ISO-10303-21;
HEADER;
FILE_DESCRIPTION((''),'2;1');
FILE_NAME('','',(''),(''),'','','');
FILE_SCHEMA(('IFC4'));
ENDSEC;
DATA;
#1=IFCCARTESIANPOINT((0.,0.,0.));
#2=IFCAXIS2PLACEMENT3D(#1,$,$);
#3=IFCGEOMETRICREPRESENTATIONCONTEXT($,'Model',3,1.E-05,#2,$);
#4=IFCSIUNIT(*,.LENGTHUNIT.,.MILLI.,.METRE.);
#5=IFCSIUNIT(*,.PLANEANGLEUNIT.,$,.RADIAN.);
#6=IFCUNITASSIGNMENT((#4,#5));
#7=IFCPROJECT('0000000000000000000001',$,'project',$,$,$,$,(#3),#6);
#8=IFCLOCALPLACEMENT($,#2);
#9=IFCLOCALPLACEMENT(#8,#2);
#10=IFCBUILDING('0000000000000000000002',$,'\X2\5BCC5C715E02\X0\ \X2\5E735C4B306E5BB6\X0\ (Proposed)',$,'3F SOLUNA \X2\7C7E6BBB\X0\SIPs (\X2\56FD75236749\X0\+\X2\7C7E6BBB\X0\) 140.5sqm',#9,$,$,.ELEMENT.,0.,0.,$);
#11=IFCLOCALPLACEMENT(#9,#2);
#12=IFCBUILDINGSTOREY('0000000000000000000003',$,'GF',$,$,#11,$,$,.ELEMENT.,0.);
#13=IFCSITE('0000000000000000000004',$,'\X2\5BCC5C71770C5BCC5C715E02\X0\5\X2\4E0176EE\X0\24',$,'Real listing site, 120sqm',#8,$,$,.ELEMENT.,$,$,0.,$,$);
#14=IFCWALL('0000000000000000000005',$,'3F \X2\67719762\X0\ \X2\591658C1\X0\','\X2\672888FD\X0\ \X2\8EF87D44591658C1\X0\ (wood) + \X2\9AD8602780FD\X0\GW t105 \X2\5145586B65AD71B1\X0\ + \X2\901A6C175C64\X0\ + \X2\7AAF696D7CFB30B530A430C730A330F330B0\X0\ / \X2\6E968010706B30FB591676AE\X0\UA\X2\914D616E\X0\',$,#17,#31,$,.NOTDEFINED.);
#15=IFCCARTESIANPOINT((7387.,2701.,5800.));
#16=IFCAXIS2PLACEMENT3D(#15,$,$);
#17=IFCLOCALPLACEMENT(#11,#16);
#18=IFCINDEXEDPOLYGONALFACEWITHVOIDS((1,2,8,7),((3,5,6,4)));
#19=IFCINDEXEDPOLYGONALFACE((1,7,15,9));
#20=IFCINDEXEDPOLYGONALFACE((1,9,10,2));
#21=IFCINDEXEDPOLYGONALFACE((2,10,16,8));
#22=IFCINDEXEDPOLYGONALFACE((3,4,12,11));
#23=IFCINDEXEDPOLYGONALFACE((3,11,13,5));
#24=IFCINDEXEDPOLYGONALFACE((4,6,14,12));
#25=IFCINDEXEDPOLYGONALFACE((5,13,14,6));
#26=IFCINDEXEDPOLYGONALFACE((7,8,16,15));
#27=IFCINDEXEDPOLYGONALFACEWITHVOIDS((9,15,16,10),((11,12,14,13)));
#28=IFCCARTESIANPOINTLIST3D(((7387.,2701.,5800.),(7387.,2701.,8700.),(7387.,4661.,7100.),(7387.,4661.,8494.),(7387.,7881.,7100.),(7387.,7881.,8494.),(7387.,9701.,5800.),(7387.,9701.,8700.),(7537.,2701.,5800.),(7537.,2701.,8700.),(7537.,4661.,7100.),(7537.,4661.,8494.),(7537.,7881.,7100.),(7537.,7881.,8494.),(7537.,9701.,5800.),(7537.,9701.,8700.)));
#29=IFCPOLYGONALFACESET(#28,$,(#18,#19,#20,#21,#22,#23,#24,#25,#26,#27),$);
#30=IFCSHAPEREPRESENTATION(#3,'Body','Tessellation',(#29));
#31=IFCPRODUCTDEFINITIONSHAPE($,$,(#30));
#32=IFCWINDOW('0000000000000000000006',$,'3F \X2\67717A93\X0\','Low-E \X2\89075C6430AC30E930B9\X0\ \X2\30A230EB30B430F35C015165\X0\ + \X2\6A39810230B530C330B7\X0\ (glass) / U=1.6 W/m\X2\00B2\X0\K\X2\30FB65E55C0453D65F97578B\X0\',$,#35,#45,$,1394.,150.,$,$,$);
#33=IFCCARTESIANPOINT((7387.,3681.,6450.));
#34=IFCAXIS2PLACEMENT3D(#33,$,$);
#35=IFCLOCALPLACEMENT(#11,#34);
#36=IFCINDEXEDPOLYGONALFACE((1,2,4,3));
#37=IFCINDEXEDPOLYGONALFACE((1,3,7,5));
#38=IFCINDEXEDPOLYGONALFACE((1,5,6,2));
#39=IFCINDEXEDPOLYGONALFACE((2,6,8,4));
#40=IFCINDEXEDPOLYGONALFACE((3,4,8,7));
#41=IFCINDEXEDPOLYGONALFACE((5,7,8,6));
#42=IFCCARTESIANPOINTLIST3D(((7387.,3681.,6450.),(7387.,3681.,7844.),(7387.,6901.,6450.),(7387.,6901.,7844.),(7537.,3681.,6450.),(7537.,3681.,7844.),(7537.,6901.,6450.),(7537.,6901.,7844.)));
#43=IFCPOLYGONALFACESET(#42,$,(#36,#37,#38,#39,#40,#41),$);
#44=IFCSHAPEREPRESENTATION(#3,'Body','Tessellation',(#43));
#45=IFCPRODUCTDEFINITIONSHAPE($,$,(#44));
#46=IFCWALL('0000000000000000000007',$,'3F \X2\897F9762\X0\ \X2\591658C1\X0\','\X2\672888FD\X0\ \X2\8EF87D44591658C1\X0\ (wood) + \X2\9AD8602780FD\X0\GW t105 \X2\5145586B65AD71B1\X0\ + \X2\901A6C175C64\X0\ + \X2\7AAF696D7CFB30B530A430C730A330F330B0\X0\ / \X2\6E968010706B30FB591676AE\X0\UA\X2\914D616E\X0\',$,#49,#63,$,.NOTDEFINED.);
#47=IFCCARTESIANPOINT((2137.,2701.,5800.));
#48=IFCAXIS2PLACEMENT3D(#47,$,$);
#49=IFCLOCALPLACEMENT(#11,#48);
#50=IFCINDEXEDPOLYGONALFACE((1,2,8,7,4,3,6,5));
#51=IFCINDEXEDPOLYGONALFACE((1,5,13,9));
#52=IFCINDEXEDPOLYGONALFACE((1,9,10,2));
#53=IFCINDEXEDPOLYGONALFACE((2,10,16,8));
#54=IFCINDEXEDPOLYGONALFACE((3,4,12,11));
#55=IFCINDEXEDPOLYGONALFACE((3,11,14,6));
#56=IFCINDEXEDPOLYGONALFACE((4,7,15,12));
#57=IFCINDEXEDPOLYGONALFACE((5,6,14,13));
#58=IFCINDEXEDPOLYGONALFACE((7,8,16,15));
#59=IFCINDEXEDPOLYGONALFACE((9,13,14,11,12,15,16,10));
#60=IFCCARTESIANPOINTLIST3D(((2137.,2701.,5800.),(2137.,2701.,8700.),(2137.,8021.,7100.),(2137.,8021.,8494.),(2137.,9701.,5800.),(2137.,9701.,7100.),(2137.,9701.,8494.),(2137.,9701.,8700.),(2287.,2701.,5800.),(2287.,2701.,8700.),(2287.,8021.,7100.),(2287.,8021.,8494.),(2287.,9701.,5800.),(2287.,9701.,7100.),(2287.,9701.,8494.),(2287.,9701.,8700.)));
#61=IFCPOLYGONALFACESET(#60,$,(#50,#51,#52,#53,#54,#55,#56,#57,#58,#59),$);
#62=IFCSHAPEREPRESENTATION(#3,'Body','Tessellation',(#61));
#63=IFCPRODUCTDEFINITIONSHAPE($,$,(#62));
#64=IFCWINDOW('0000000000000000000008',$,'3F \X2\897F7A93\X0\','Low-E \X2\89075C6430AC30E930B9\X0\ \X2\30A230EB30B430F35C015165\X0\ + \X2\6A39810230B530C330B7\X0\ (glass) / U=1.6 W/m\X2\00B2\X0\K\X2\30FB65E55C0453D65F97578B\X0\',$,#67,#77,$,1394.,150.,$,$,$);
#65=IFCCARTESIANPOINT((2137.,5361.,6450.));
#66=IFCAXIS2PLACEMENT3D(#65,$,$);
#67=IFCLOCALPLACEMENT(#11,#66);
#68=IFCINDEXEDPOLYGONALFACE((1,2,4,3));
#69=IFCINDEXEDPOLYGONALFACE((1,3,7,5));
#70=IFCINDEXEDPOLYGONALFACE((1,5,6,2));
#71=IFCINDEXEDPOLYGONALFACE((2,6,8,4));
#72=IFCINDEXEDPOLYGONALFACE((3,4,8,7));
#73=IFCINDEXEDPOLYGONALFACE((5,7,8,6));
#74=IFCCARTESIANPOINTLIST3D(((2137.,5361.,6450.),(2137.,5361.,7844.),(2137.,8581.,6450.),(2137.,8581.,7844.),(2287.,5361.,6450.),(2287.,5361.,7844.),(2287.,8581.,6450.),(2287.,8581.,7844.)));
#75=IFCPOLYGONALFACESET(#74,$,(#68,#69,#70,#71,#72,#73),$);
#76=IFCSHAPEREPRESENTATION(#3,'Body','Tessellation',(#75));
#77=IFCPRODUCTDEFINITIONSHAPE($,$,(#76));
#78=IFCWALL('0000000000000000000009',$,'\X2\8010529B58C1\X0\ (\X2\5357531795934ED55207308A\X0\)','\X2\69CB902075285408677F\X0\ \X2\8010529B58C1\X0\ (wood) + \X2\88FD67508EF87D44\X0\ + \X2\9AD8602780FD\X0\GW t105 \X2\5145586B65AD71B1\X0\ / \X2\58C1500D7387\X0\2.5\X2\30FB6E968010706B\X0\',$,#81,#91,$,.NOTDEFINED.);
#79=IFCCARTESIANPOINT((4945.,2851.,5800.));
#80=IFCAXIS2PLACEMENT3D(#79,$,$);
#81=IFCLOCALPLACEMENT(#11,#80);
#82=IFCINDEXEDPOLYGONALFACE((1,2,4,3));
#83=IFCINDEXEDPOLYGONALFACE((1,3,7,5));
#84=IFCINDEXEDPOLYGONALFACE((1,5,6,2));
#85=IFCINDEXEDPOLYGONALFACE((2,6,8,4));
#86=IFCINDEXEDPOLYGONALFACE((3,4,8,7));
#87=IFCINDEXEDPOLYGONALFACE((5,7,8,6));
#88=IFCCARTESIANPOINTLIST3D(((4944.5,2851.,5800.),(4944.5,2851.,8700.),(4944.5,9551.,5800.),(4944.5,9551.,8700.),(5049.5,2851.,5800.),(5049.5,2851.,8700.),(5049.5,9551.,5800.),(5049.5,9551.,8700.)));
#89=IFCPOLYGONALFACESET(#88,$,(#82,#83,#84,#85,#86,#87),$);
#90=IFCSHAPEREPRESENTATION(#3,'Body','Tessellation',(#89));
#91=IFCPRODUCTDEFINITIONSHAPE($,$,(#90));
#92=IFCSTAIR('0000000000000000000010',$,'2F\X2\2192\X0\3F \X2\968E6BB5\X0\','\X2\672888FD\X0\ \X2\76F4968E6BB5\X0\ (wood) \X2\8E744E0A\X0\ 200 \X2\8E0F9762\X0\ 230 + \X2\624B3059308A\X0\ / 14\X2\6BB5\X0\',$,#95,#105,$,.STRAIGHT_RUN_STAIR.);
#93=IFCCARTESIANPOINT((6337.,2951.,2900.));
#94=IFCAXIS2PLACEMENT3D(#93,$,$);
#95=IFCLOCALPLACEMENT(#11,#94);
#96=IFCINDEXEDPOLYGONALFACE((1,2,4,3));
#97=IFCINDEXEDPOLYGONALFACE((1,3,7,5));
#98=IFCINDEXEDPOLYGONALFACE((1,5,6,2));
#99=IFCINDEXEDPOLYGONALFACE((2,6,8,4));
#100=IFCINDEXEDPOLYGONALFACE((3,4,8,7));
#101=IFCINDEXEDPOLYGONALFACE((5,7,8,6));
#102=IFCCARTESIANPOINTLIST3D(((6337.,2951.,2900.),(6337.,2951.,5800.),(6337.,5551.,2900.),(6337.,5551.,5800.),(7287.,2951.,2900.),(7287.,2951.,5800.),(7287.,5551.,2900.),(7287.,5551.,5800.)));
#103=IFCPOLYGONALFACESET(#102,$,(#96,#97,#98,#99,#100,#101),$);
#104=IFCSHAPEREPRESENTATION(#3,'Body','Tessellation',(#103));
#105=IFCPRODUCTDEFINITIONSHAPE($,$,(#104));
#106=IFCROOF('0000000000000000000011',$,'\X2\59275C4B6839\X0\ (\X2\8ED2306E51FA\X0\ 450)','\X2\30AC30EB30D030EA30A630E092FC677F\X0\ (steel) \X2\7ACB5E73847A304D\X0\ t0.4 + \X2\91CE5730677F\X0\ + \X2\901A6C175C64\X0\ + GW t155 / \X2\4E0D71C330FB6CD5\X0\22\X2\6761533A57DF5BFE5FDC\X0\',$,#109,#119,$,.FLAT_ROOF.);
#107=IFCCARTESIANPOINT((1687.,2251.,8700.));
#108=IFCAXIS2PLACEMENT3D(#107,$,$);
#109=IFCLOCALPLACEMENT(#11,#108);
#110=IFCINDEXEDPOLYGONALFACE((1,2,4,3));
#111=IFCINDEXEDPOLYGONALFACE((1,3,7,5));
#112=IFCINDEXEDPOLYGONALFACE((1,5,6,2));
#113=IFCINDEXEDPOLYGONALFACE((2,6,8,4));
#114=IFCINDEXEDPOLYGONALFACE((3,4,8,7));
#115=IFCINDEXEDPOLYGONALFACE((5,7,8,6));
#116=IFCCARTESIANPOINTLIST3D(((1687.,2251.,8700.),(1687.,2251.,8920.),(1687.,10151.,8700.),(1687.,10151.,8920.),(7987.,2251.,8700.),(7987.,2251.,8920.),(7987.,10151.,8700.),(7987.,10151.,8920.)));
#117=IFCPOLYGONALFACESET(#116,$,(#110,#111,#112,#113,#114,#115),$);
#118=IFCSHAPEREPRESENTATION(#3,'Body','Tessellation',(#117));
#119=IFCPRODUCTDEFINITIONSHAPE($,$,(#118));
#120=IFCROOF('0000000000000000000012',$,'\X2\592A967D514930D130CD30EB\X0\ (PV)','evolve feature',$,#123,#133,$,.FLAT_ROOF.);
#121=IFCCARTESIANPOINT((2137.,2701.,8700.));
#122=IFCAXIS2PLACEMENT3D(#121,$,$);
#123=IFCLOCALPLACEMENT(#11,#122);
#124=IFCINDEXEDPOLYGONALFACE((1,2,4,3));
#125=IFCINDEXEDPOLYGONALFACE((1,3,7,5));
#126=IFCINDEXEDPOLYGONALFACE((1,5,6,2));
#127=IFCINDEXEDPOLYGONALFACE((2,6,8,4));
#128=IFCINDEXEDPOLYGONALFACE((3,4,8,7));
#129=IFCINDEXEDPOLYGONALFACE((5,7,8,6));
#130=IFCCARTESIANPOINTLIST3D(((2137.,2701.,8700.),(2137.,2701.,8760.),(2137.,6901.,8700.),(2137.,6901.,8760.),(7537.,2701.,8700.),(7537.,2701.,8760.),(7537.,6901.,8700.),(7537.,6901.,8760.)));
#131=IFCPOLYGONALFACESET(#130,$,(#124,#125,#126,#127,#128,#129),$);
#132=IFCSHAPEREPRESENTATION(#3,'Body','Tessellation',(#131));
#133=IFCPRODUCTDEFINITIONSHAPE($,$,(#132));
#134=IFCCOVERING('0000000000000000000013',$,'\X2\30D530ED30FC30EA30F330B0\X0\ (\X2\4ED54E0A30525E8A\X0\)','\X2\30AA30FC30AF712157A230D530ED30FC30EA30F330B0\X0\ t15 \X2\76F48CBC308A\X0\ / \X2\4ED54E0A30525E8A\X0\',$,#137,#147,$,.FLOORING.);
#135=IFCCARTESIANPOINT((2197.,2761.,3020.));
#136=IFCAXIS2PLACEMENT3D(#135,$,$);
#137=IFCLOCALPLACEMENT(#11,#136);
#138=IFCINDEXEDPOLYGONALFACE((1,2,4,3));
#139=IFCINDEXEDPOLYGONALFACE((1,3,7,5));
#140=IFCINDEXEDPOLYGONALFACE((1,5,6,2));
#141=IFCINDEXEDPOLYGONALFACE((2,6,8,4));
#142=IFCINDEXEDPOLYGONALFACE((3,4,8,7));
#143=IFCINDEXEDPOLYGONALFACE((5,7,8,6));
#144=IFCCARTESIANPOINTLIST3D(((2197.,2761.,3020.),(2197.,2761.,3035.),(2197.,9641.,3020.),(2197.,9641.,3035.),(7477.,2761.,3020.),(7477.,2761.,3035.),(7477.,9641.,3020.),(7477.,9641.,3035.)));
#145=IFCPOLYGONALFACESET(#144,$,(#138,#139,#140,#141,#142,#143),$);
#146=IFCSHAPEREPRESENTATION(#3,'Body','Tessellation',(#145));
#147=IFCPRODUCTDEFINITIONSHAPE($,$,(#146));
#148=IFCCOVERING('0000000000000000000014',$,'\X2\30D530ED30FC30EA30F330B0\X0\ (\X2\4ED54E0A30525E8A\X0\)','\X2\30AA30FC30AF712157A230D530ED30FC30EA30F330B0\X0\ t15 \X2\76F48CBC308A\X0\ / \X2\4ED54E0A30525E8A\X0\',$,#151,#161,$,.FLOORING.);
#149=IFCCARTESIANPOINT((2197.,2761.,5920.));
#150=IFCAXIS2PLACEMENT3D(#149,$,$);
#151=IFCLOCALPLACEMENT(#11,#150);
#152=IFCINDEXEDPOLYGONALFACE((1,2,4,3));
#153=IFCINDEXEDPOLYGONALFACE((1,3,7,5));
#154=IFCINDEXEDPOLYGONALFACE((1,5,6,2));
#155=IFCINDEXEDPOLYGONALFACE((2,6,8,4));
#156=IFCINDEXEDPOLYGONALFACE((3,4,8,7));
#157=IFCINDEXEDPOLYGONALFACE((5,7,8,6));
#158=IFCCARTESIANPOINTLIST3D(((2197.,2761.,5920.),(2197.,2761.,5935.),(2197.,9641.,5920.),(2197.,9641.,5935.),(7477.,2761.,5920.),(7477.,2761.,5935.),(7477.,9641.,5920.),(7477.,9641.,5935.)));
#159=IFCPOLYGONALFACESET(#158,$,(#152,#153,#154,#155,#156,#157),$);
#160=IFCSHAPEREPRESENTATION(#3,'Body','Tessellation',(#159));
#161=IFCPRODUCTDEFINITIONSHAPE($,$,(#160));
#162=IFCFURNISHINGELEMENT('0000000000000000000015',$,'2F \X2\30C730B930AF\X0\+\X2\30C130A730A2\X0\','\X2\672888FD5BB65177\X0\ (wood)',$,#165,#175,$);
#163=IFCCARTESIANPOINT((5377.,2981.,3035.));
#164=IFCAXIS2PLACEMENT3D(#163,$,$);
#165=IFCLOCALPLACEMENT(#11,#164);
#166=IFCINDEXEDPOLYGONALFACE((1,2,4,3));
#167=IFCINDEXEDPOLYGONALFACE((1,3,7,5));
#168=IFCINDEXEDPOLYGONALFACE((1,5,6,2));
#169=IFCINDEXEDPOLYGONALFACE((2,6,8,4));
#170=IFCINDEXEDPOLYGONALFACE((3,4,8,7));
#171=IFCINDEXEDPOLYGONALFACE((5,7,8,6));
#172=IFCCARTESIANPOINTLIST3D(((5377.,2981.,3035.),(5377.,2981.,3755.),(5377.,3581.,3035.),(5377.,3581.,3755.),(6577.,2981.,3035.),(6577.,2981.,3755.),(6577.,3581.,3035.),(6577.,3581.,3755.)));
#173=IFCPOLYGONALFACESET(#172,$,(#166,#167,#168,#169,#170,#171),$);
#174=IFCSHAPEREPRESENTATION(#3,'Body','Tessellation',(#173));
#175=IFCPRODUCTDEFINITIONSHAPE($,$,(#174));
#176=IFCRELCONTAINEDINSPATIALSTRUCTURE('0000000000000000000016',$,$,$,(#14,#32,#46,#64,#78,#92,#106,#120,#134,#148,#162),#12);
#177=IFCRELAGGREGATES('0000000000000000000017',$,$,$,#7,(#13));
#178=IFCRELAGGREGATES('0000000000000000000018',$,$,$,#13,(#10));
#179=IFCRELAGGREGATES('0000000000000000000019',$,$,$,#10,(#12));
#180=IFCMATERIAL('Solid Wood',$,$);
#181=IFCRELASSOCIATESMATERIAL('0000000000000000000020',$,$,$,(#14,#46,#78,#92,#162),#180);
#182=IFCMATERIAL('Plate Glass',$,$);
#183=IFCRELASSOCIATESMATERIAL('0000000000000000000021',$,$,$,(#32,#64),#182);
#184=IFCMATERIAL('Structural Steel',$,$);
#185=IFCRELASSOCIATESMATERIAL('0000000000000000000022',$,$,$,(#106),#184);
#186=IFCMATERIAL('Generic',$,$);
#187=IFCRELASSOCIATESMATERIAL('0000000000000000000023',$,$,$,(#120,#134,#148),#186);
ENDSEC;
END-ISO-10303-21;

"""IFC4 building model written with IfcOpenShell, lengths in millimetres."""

from ifc_helpers import new_model, si_unit, frame, frame_2d, origin, place, context, project, spatial, rectangle, extrude, material, element, fill, save


model = new_model("IFC4")

# Units and contexts
model_context = context("Model", 3, precision=1e-05, world=origin())
ifc_project = project(units=[si_unit("LENGTHUNIT", "METRE", prefix="MILLI"), si_unit("PLANEANGLEUNIT", "RADIAN")], contexts=[model_context])

# Site, building, storey
site_placement = place(None, origin())
site = spatial("IfcSite", under=ifc_project, at=site_placement, Name="富山県富山市5丁目24", ObjectType="Real listing site, 120sqm", CompositionType="ELEMENT", RefElevation=0.0)
building_placement = place(site_placement, origin())
building = spatial("IfcBuilding", under=site, at=building_placement, Name="富山市 平屋の家 (Proposed)", ObjectType="3F SOLUNA 籾殻SIPs (国産杉+籾殻) 140.5sqm", CompositionType="ELEMENT", ElevationOfRefHeight=0.0, ElevationOfTerrain=0.0)
storey_placement = place(building_placement, origin())
storey = spatial("IfcBuildingStorey", under=building, at=storey_placement, Name="GF", CompositionType="ELEMENT", Elevation=0.0)

# Shared definitions
ifc_material_1 = material(Name="Solid Wood")

# Shared definitions
ifc_material_2 = material(Name="Plate Glass")

# Shared definitions
ifc_material_3 = material(Name="Generic")

# Walls, openings, windows
wall_1_placement = place(storey_placement, frame((7387.0, 2701.0, 5800.0)))
wall_1 = element("IfcWall", 1, at=wall_1_placement, inside=storey, material=ifc_material_1, Name="3F 東面 外壁", Description="木製 軸組外壁 (wood) + 高性能GW t105 充填断熱 + 通気層 + 窯業系サイディング / 準耐火・外皮UA配慮", PredefinedType="NOTDEFINED", context=model_context, shape_type="SweptSolid", body=[
    extrude(rectangle(XDim=150.0, YDim=7000.0, at=frame_2d((75.0, 3500.0))), frame((7387.0, 2701.0, 5800.0)), (0.0, 0.0, 1.0), 2900.0),
])
opening_1_placement = place(storey_placement, frame((7387.0, 3681.0, 6450.0)))
opening_1 = element("IfcOpeningElement", 2, at=opening_1_placement, cuts=wall_1, PredefinedType="NOTDEFINED", context=model_context, shape_type="SweptSolid", body=[
    extrude(rectangle(XDim=150.0, YDim=3220.0, at=frame_2d((75.0, 1610.0))), frame((7387.0, 3681.0, 6450.0)), (0.0, 0.0, 1.0), 1394.0),
])
window_1_placement = place(storey_placement, frame((7387.0, 3681.0, 6450.0)))
window_1 = element("IfcWindow", 3, at=window_1_placement, inside=storey, material=ifc_material_2, Name="3F 東窓", Description="Low-E 複層ガラス アルゴン封入 + 樹脂サッシ (glass) / U=1.6 W/m²K・日射取得型", OverallHeight=1394.0, OverallWidth=150.0, context=model_context, shape_type="SweptSolid", body=[
    extrude(rectangle(XDim=150.0, YDim=3220.0, at=frame_2d((75.0, 1610.0))), frame((7387.0, 3681.0, 6450.0)), (0.0, 0.0, 1.0), 1394.0),
])
fill(opening_1, window_1)
wall_2_placement = place(storey_placement, frame((2137.0, 2701.0, 5800.0)))
wall_2 = element("IfcWall", 4, at=wall_2_placement, inside=storey, material=ifc_material_1, Name="3F 西面 外壁", Description="木製 軸組外壁 (wood) + 高性能GW t105 充填断熱 + 通気層 + 窯業系サイディング / 準耐火・外皮UA配慮", PredefinedType="NOTDEFINED", context=model_context, shape_type="SweptSolid", body=[
    extrude(rectangle(XDim=150.0, YDim=7000.0, at=frame_2d((75.0, 3500.0))), frame((2137.0, 2701.0, 5800.0)), (0.0, 0.0, 1.0), 2900.0),
])
opening_2_placement = place(storey_placement, frame((2137.0, 5361.0, 6450.0)))
opening_2 = element("IfcOpeningElement", 5, at=opening_2_placement, cuts=wall_2, PredefinedType="NOTDEFINED", context=model_context, shape_type="SweptSolid", body=[
    extrude(rectangle(XDim=150.0, YDim=3220.0, at=frame_2d((75.0, 1610.0))), frame((2137.0, 5361.0, 6450.0)), (0.0, 0.0, 1.0), 1394.0),
])
window_2_placement = place(storey_placement, frame((2137.0, 5361.0, 6450.0)))
window_2 = element("IfcWindow", 6, at=window_2_placement, inside=storey, material=ifc_material_2, Name="3F 西窓", Description="Low-E 複層ガラス アルゴン封入 + 樹脂サッシ (glass) / U=1.6 W/m²K・日射取得型", OverallHeight=1394.0, OverallWidth=150.0, context=model_context, shape_type="SweptSolid", body=[
    extrude(rectangle(XDim=150.0, YDim=3220.0, at=frame_2d((75.0, 1610.0))), frame((2137.0, 5361.0, 6450.0)), (0.0, 0.0, 1.0), 1394.0),
])
fill(opening_2, window_2)

# Wall
wall_3_placement = place(storey_placement, frame((4945.0, 2851.0, 5800.0)))
element("IfcWall", 7, at=wall_3_placement, inside=storey, material=ifc_material_1, Name="耐力壁 (南北間仕切り)", Description="構造用合板 耐力壁 (wood) + 製材軸組 + 高性能GW t105 充填断熱 / 壁倍率2.5・準耐火", PredefinedType="NOTDEFINED", context=model_context, shape_type="SweptSolid", body=[
    extrude(rectangle(XDim=105.0, YDim=6700.0, at=frame_2d((52.0, 3350.0))), frame((4945.0, 2851.0, 5800.0)), (0.0, 0.0, 1.0), 2900.0),
])

# Stair
stair_placement = place(storey_placement, frame((6337.0, 2951.0, 2900.0)))
element("IfcStair", 8, at=stair_placement, inside=storey, material=ifc_material_1, Name="2F→3F 階段", Description="木製 直階段 (wood) 蹴上 200 踏面 230 + 手すり / 14段", PredefinedType="STRAIGHT_RUN_STAIR", context=model_context, shape_type="SweptSolid", body=[
    extrude(rectangle(XDim=950.0, YDim=2600.0, at=frame_2d((475.0, 1300.0))), frame((6337.0, 2951.0, 2900.0)), (0.0, 0.0, 1.0), 2900.0),
])

# Roofs
ifc_material_4 = material(Name="Structural Steel")
roof_1_placement = place(storey_placement, frame((1687.0, 2251.0, 8700.0)))
element("IfcRoof", 9, at=roof_1_placement, inside=storey, material=ifc_material_4, Name="大屋根 (軒の出 450)", Description="ガルバリウム鋼板 (steel) 立平葺き t0.4 + 野地板 + 通気層 + GW t155 / 不燃・法22条区域対応", PredefinedType="FLAT_ROOF", context=model_context, shape_type="SweptSolid", body=[
    extrude(rectangle(XDim=6300.0, YDim=7900.0, at=frame_2d((3150.0, 3950.0))), frame((1687.0, 2251.0, 8700.0)), (0.0, 0.0, 1.0), 220.0),
])
roof_2_placement = place(storey_placement, frame((2137.0, 2701.0, 8700.0)))
element("IfcRoof", 10, at=roof_2_placement, inside=storey, material=ifc_material_3, Name="太陽光パネル (PV)", Description="evolve feature", PredefinedType="FLAT_ROOF", context=model_context, shape_type="SweptSolid", body=[
    extrude(rectangle(XDim=5400.0, YDim=4200.0, at=frame_2d((2700.0, 2100.0))), frame((2137.0, 2701.0, 8700.0)), (0.0, 0.0, 1.0), 60.0),
])

# Coverings
covering_1_placement = place(storey_placement, frame((2197.0, 2761.0, 3020.0)))
element("IfcCovering", 11, at=covering_1_placement, inside=storey, material=ifc_material_3, Name="フローリング (仕上げ床)", Description="オーク無垢フローリング t15 直貼り / 仕上げ床", PredefinedType="FLOORING", context=model_context, shape_type="SweptSolid", body=[
    extrude(rectangle(XDim=5280.0, YDim=6880.0, at=frame_2d((2640.0, 3440.0))), frame((2197.0, 2761.0, 3020.0)), (0.0, 0.0, 1.0), 15.0),
])
covering_2_placement = place(storey_placement, frame((2197.0, 2761.0, 5920.0)))
element("IfcCovering", 12, at=covering_2_placement, inside=storey, material=ifc_material_3, Name="フローリング (仕上げ床)", Description="オーク無垢フローリング t15 直貼り / 仕上げ床", PredefinedType="FLOORING", context=model_context, shape_type="SweptSolid", body=[
    extrude(rectangle(XDim=5280.0, YDim=6880.0, at=frame_2d((2640.0, 3440.0))), frame((2197.0, 2761.0, 5920.0)), (0.0, 0.0, 1.0), 15.0),
])

# Furnishing element
furnishing_placement = place(storey_placement, frame((5377.0, 2981.0, 3035.0)))
element("IfcFurnishingElement", 13, at=furnishing_placement, inside=storey, material=ifc_material_1, Name="2F デスク+チェア", Description="木製家具 (wood)", context=model_context, shape_type="SweptSolid", body=[
    extrude(rectangle(XDim=1200.0, YDim=600.0, at=frame_2d((600.0, 300.0))), frame((5377.0, 2981.0, 3035.0)), (0.0, 0.0, 1.0), 720.0),
])

save(model, "model.ifc")
